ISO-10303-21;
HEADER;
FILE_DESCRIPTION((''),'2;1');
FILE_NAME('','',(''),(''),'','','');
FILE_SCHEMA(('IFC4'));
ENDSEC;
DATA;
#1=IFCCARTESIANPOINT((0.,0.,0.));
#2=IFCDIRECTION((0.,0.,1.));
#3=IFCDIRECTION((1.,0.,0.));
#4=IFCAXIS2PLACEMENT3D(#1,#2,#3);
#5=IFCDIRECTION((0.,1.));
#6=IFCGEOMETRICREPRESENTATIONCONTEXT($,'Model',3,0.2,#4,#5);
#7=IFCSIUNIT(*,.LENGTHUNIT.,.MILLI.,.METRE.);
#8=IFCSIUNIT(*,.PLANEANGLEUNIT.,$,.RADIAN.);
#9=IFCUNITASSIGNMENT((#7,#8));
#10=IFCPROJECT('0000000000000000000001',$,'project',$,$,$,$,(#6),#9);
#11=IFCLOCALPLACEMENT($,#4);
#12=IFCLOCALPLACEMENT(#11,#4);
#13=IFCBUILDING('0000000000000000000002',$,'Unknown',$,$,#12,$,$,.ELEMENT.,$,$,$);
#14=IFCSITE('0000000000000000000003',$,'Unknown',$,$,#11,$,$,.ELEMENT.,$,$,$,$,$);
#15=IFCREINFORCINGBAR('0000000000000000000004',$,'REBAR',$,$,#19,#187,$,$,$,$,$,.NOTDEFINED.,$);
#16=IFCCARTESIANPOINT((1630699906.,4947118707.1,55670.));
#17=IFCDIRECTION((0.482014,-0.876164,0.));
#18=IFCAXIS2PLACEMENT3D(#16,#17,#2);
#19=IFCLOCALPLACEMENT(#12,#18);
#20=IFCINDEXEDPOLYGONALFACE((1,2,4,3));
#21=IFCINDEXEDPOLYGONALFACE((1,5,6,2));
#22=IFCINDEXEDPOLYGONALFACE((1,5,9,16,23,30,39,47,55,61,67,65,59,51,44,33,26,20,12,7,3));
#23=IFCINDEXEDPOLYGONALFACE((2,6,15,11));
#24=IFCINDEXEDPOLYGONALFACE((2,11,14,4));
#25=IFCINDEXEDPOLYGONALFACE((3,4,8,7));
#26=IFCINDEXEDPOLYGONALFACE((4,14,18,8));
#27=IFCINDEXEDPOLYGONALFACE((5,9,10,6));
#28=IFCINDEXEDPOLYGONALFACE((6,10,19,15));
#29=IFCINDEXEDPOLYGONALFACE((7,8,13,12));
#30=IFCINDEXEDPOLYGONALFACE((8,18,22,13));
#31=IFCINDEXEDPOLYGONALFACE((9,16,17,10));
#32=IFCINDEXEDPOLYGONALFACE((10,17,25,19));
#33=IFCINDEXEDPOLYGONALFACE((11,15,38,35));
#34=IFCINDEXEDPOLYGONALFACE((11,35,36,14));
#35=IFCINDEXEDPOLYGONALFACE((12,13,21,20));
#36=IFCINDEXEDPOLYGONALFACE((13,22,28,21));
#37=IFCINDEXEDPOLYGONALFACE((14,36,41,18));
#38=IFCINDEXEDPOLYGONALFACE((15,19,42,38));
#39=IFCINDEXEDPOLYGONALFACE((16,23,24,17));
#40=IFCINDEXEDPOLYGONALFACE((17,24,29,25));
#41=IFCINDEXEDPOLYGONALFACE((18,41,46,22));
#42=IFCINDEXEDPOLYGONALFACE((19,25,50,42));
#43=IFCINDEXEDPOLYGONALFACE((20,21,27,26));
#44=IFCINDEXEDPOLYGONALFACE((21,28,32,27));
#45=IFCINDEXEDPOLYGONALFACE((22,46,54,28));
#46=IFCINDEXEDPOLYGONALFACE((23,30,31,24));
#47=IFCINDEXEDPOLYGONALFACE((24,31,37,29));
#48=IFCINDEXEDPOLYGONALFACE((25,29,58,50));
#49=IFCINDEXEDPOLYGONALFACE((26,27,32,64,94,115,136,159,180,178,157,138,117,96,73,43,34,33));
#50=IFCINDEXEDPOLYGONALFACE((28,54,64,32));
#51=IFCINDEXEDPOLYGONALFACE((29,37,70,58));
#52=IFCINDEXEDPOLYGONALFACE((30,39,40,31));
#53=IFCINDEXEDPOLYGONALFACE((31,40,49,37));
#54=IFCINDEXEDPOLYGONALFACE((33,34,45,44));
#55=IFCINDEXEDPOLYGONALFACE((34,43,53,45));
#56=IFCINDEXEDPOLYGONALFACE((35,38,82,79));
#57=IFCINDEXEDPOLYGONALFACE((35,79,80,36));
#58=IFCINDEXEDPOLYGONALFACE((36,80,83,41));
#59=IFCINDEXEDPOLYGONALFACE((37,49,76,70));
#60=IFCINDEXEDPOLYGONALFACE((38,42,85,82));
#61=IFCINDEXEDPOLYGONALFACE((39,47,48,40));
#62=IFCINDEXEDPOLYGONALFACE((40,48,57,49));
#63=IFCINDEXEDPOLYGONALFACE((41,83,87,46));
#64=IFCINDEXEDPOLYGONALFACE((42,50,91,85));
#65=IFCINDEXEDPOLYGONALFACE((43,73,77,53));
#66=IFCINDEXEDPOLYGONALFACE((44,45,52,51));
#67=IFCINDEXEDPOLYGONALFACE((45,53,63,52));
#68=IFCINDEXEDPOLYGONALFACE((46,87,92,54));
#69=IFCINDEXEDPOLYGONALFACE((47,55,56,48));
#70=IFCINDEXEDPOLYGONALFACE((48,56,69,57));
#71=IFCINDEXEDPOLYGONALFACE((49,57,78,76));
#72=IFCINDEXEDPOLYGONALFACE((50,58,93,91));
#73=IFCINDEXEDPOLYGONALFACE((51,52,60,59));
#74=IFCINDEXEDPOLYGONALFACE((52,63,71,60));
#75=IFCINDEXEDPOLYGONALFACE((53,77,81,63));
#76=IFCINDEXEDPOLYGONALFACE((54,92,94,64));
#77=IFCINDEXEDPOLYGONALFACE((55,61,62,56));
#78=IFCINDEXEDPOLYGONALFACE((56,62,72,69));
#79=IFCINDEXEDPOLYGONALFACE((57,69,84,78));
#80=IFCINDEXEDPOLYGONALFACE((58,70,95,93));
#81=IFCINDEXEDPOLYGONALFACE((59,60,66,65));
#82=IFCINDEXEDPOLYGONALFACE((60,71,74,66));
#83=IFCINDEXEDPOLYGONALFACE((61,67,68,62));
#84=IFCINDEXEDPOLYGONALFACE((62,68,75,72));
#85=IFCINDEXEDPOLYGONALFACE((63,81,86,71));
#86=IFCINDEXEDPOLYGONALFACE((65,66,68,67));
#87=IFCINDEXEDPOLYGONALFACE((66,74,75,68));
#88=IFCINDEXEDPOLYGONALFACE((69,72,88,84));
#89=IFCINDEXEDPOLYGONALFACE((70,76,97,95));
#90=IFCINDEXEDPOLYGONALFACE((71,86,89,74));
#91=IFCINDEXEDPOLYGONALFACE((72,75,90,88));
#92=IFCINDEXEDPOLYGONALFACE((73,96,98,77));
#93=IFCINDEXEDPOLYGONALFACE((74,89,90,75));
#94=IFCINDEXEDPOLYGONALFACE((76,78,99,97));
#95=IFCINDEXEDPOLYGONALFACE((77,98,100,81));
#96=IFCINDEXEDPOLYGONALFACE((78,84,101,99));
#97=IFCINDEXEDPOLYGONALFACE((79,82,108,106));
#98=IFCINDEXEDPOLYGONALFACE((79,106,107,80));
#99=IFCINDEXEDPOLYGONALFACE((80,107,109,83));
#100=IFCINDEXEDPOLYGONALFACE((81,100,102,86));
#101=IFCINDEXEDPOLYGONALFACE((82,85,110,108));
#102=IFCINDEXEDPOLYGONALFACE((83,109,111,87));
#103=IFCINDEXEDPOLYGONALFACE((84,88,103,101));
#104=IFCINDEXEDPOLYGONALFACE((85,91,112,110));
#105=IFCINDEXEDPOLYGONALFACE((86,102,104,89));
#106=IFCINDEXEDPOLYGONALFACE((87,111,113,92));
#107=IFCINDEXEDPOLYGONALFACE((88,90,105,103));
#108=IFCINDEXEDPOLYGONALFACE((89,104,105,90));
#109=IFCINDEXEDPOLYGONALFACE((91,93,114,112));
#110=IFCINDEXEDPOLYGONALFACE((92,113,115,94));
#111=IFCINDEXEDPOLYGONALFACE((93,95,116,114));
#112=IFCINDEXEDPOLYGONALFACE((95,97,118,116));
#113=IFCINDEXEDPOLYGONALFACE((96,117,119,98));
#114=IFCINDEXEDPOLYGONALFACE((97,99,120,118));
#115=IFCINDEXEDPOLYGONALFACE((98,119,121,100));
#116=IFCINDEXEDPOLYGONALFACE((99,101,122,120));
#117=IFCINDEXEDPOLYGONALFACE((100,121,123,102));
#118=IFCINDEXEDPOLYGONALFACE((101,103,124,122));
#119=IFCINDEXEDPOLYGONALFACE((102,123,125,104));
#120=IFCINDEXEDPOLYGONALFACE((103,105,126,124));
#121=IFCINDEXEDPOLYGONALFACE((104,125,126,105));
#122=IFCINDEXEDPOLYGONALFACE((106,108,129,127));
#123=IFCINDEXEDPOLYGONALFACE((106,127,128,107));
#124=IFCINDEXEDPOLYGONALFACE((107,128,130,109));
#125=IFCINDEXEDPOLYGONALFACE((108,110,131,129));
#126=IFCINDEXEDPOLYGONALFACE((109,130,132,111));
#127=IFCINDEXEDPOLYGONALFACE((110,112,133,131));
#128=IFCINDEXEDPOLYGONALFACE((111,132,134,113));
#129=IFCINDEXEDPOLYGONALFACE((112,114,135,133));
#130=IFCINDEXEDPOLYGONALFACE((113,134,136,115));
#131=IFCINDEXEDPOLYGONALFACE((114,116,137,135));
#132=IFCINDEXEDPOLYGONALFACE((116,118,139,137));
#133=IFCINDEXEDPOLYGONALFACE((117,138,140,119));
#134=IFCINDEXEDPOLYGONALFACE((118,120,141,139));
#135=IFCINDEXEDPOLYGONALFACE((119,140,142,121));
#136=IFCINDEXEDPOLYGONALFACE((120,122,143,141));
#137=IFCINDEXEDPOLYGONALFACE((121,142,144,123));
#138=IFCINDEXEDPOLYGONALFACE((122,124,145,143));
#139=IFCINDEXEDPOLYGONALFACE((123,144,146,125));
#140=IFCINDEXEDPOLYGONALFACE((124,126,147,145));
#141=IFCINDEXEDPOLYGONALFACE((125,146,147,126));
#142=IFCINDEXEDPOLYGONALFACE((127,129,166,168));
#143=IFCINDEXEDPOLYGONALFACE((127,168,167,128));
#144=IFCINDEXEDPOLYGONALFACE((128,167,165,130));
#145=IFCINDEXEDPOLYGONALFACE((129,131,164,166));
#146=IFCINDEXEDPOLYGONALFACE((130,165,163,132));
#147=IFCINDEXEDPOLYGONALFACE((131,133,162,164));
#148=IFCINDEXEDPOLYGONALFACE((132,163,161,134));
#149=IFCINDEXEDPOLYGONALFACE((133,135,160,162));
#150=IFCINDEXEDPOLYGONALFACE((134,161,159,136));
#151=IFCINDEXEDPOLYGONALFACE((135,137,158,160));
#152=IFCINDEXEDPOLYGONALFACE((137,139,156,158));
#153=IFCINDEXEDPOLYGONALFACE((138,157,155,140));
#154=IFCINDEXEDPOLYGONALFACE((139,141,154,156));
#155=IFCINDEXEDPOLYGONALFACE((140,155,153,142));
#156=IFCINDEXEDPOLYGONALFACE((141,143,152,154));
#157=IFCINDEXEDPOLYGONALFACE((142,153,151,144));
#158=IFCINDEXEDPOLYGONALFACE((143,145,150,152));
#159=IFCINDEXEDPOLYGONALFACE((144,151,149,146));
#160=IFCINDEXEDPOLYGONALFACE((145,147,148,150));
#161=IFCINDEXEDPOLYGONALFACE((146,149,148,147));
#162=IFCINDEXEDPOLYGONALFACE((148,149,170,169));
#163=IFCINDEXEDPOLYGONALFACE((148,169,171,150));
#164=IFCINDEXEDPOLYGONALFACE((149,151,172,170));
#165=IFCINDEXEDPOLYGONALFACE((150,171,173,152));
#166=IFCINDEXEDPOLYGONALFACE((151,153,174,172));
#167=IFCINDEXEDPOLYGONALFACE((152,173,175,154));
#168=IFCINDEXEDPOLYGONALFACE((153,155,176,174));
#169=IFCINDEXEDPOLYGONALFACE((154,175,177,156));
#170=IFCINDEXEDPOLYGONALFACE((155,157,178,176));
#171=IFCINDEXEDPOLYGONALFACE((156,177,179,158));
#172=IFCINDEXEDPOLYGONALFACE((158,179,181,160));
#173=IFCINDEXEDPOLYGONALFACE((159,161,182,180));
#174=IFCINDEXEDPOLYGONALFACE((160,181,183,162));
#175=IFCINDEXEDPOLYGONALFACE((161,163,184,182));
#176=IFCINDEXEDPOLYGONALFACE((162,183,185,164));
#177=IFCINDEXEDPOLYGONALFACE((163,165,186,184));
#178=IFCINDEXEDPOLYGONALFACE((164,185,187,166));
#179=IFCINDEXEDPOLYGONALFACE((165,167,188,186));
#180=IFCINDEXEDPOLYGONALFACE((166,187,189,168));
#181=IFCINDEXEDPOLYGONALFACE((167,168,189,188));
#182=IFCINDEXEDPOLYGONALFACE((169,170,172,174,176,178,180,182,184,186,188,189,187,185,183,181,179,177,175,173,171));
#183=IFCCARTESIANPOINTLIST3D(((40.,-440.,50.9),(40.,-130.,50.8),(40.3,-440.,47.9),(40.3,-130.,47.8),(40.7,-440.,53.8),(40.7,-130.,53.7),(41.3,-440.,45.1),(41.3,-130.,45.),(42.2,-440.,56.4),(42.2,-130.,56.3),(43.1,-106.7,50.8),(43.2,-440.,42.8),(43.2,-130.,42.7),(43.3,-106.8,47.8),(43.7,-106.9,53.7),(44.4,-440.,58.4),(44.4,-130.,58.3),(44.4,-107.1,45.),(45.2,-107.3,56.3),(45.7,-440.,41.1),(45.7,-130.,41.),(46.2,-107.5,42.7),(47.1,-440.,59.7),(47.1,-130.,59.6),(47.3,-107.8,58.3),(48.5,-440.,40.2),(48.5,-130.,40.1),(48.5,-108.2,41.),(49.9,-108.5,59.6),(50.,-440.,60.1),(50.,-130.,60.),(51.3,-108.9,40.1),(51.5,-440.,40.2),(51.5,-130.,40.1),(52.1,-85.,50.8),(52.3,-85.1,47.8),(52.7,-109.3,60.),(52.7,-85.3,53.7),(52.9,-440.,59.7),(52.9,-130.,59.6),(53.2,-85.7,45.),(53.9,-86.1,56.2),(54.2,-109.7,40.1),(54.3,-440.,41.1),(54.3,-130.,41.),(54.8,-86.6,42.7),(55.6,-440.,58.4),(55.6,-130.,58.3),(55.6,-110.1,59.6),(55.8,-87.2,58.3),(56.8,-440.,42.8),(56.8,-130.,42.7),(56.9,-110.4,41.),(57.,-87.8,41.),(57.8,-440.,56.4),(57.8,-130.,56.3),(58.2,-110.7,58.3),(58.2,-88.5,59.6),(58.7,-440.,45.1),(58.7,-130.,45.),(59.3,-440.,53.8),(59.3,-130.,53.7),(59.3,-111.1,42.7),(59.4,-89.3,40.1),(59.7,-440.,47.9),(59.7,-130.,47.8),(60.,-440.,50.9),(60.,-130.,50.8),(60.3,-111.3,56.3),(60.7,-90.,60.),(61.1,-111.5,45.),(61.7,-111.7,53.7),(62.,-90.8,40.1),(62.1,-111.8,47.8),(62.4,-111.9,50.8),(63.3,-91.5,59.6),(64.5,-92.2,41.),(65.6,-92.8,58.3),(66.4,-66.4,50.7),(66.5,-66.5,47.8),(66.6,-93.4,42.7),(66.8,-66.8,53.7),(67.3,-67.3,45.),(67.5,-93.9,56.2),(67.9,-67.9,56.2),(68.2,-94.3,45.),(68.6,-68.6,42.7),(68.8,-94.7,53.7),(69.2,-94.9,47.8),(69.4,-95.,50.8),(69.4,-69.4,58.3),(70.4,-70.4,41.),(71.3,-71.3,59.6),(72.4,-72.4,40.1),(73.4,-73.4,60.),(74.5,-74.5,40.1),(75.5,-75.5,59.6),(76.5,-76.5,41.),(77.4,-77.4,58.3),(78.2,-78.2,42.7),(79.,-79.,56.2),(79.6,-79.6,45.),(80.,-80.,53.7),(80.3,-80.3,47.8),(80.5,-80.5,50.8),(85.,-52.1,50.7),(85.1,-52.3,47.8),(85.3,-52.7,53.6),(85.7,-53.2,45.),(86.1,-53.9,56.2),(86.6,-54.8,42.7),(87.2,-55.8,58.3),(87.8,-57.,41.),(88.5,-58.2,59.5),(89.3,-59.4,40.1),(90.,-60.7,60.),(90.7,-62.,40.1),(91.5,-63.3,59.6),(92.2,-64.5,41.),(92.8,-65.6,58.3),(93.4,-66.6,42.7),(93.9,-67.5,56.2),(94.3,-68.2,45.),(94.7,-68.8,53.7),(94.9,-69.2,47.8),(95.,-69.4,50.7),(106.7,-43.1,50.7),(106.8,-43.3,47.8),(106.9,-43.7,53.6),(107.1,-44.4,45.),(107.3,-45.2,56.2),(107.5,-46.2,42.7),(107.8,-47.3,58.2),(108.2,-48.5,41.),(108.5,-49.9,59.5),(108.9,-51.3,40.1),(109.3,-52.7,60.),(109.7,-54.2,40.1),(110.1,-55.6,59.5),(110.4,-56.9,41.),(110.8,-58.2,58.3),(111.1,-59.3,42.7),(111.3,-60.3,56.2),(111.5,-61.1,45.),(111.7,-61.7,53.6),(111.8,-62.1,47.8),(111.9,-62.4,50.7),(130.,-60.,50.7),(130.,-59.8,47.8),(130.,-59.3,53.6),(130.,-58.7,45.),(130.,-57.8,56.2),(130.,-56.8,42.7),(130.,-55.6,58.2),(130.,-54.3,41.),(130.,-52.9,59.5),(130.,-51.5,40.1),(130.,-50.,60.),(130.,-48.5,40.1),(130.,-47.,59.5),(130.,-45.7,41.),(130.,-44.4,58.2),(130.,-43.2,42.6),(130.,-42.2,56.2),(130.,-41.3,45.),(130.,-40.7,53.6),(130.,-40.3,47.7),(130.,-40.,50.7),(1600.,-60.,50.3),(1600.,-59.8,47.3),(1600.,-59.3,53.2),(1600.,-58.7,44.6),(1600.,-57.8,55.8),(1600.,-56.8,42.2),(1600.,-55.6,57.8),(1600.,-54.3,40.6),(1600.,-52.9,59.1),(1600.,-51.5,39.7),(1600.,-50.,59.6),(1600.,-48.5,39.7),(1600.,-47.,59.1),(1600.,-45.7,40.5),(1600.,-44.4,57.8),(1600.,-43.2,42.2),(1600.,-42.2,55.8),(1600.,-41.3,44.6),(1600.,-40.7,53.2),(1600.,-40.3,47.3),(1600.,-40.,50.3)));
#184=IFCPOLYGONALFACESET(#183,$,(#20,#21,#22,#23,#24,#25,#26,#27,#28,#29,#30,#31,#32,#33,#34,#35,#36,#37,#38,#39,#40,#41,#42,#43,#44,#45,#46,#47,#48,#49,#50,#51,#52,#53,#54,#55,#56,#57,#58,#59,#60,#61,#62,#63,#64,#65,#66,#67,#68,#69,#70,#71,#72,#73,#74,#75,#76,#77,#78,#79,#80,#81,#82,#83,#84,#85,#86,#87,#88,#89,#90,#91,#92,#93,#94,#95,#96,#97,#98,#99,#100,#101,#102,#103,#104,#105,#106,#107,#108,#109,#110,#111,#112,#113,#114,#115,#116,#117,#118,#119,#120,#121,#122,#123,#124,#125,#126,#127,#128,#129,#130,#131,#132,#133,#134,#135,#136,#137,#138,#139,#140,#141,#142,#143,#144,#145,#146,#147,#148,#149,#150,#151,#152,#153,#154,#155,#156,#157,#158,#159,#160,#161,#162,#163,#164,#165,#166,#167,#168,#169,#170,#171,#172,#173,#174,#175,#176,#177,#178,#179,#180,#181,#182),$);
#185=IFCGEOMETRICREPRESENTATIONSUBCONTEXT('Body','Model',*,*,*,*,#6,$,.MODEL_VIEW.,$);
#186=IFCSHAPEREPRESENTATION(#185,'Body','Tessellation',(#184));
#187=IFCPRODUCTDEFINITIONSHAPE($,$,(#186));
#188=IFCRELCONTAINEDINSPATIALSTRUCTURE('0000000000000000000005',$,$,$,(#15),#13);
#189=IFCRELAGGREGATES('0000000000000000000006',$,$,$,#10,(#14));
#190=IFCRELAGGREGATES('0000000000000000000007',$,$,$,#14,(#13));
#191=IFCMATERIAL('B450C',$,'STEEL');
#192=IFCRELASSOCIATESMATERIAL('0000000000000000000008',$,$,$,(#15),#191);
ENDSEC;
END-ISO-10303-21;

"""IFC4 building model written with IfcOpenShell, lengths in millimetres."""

from ifc_helpers import new_model, entity, si_unit, direction, frame, origin_with_axes, place, context, subcontext, project, spatial, material, element, save


model = new_model("IFC4")

# Units and contexts
model_context = context("Model", 3, precision=0.2, world=origin_with_axes(), true_north=direction((0.0, 1.0)))
body_context = subcontext(model_context, "Body", "Model", "MODEL_VIEW")
ifc_project = project(units=[si_unit("LENGTHUNIT", "METRE", prefix="MILLI"), si_unit("PLANEANGLEUNIT", "RADIAN")], contexts=[model_context])

# Site, building
site_placement = place(None, origin_with_axes())
site = spatial("IfcSite", under=ifc_project, at=site_placement, Name="Unknown", CompositionType="ELEMENT")
building_placement = place(site_placement, origin_with_axes())
building = spatial("IfcBuilding", under=site, at=building_placement, Name="Unknown", CompositionType="ELEMENT")

# Reinforcing bar
ifc_material = material(Name="B450C", Category="STEEL")
reinforcing_bar_1_placement = place(building_placement, frame((1630699906.0, 4947118707.1, 55670.0), z_axis=(0.482014, -0.876164, 0.0), x_axis=(0.0, 0.0, 1.0)))
element("IfcReinforcingBar", 1, at=reinforcing_bar_1_placement, inside=building, material=ifc_material, Name="REBAR", PredefinedType="NOTDEFINED", context=body_context, shape_type="AdvancedSweptSolid", body=[
    entity("IfcSweptDiskSolid", entity("IfcIndexedPolyCurve", entity("IfcCartesianPointList3D", [[50.0, -440.0, 50.1], [50.0, -130.0, 50.0], [73.4, -73.4, 50.0], [130.0, -50.0, 50.0], [1600.0, -50.0, 49.6]]), [entity("IfcLineIndex", [1, 2]), entity("IfcArcIndex", [2, 3, 4]), entity("IfcLineIndex", [4, 5])]), 10.0),
])

save(model, "model.ifc")
